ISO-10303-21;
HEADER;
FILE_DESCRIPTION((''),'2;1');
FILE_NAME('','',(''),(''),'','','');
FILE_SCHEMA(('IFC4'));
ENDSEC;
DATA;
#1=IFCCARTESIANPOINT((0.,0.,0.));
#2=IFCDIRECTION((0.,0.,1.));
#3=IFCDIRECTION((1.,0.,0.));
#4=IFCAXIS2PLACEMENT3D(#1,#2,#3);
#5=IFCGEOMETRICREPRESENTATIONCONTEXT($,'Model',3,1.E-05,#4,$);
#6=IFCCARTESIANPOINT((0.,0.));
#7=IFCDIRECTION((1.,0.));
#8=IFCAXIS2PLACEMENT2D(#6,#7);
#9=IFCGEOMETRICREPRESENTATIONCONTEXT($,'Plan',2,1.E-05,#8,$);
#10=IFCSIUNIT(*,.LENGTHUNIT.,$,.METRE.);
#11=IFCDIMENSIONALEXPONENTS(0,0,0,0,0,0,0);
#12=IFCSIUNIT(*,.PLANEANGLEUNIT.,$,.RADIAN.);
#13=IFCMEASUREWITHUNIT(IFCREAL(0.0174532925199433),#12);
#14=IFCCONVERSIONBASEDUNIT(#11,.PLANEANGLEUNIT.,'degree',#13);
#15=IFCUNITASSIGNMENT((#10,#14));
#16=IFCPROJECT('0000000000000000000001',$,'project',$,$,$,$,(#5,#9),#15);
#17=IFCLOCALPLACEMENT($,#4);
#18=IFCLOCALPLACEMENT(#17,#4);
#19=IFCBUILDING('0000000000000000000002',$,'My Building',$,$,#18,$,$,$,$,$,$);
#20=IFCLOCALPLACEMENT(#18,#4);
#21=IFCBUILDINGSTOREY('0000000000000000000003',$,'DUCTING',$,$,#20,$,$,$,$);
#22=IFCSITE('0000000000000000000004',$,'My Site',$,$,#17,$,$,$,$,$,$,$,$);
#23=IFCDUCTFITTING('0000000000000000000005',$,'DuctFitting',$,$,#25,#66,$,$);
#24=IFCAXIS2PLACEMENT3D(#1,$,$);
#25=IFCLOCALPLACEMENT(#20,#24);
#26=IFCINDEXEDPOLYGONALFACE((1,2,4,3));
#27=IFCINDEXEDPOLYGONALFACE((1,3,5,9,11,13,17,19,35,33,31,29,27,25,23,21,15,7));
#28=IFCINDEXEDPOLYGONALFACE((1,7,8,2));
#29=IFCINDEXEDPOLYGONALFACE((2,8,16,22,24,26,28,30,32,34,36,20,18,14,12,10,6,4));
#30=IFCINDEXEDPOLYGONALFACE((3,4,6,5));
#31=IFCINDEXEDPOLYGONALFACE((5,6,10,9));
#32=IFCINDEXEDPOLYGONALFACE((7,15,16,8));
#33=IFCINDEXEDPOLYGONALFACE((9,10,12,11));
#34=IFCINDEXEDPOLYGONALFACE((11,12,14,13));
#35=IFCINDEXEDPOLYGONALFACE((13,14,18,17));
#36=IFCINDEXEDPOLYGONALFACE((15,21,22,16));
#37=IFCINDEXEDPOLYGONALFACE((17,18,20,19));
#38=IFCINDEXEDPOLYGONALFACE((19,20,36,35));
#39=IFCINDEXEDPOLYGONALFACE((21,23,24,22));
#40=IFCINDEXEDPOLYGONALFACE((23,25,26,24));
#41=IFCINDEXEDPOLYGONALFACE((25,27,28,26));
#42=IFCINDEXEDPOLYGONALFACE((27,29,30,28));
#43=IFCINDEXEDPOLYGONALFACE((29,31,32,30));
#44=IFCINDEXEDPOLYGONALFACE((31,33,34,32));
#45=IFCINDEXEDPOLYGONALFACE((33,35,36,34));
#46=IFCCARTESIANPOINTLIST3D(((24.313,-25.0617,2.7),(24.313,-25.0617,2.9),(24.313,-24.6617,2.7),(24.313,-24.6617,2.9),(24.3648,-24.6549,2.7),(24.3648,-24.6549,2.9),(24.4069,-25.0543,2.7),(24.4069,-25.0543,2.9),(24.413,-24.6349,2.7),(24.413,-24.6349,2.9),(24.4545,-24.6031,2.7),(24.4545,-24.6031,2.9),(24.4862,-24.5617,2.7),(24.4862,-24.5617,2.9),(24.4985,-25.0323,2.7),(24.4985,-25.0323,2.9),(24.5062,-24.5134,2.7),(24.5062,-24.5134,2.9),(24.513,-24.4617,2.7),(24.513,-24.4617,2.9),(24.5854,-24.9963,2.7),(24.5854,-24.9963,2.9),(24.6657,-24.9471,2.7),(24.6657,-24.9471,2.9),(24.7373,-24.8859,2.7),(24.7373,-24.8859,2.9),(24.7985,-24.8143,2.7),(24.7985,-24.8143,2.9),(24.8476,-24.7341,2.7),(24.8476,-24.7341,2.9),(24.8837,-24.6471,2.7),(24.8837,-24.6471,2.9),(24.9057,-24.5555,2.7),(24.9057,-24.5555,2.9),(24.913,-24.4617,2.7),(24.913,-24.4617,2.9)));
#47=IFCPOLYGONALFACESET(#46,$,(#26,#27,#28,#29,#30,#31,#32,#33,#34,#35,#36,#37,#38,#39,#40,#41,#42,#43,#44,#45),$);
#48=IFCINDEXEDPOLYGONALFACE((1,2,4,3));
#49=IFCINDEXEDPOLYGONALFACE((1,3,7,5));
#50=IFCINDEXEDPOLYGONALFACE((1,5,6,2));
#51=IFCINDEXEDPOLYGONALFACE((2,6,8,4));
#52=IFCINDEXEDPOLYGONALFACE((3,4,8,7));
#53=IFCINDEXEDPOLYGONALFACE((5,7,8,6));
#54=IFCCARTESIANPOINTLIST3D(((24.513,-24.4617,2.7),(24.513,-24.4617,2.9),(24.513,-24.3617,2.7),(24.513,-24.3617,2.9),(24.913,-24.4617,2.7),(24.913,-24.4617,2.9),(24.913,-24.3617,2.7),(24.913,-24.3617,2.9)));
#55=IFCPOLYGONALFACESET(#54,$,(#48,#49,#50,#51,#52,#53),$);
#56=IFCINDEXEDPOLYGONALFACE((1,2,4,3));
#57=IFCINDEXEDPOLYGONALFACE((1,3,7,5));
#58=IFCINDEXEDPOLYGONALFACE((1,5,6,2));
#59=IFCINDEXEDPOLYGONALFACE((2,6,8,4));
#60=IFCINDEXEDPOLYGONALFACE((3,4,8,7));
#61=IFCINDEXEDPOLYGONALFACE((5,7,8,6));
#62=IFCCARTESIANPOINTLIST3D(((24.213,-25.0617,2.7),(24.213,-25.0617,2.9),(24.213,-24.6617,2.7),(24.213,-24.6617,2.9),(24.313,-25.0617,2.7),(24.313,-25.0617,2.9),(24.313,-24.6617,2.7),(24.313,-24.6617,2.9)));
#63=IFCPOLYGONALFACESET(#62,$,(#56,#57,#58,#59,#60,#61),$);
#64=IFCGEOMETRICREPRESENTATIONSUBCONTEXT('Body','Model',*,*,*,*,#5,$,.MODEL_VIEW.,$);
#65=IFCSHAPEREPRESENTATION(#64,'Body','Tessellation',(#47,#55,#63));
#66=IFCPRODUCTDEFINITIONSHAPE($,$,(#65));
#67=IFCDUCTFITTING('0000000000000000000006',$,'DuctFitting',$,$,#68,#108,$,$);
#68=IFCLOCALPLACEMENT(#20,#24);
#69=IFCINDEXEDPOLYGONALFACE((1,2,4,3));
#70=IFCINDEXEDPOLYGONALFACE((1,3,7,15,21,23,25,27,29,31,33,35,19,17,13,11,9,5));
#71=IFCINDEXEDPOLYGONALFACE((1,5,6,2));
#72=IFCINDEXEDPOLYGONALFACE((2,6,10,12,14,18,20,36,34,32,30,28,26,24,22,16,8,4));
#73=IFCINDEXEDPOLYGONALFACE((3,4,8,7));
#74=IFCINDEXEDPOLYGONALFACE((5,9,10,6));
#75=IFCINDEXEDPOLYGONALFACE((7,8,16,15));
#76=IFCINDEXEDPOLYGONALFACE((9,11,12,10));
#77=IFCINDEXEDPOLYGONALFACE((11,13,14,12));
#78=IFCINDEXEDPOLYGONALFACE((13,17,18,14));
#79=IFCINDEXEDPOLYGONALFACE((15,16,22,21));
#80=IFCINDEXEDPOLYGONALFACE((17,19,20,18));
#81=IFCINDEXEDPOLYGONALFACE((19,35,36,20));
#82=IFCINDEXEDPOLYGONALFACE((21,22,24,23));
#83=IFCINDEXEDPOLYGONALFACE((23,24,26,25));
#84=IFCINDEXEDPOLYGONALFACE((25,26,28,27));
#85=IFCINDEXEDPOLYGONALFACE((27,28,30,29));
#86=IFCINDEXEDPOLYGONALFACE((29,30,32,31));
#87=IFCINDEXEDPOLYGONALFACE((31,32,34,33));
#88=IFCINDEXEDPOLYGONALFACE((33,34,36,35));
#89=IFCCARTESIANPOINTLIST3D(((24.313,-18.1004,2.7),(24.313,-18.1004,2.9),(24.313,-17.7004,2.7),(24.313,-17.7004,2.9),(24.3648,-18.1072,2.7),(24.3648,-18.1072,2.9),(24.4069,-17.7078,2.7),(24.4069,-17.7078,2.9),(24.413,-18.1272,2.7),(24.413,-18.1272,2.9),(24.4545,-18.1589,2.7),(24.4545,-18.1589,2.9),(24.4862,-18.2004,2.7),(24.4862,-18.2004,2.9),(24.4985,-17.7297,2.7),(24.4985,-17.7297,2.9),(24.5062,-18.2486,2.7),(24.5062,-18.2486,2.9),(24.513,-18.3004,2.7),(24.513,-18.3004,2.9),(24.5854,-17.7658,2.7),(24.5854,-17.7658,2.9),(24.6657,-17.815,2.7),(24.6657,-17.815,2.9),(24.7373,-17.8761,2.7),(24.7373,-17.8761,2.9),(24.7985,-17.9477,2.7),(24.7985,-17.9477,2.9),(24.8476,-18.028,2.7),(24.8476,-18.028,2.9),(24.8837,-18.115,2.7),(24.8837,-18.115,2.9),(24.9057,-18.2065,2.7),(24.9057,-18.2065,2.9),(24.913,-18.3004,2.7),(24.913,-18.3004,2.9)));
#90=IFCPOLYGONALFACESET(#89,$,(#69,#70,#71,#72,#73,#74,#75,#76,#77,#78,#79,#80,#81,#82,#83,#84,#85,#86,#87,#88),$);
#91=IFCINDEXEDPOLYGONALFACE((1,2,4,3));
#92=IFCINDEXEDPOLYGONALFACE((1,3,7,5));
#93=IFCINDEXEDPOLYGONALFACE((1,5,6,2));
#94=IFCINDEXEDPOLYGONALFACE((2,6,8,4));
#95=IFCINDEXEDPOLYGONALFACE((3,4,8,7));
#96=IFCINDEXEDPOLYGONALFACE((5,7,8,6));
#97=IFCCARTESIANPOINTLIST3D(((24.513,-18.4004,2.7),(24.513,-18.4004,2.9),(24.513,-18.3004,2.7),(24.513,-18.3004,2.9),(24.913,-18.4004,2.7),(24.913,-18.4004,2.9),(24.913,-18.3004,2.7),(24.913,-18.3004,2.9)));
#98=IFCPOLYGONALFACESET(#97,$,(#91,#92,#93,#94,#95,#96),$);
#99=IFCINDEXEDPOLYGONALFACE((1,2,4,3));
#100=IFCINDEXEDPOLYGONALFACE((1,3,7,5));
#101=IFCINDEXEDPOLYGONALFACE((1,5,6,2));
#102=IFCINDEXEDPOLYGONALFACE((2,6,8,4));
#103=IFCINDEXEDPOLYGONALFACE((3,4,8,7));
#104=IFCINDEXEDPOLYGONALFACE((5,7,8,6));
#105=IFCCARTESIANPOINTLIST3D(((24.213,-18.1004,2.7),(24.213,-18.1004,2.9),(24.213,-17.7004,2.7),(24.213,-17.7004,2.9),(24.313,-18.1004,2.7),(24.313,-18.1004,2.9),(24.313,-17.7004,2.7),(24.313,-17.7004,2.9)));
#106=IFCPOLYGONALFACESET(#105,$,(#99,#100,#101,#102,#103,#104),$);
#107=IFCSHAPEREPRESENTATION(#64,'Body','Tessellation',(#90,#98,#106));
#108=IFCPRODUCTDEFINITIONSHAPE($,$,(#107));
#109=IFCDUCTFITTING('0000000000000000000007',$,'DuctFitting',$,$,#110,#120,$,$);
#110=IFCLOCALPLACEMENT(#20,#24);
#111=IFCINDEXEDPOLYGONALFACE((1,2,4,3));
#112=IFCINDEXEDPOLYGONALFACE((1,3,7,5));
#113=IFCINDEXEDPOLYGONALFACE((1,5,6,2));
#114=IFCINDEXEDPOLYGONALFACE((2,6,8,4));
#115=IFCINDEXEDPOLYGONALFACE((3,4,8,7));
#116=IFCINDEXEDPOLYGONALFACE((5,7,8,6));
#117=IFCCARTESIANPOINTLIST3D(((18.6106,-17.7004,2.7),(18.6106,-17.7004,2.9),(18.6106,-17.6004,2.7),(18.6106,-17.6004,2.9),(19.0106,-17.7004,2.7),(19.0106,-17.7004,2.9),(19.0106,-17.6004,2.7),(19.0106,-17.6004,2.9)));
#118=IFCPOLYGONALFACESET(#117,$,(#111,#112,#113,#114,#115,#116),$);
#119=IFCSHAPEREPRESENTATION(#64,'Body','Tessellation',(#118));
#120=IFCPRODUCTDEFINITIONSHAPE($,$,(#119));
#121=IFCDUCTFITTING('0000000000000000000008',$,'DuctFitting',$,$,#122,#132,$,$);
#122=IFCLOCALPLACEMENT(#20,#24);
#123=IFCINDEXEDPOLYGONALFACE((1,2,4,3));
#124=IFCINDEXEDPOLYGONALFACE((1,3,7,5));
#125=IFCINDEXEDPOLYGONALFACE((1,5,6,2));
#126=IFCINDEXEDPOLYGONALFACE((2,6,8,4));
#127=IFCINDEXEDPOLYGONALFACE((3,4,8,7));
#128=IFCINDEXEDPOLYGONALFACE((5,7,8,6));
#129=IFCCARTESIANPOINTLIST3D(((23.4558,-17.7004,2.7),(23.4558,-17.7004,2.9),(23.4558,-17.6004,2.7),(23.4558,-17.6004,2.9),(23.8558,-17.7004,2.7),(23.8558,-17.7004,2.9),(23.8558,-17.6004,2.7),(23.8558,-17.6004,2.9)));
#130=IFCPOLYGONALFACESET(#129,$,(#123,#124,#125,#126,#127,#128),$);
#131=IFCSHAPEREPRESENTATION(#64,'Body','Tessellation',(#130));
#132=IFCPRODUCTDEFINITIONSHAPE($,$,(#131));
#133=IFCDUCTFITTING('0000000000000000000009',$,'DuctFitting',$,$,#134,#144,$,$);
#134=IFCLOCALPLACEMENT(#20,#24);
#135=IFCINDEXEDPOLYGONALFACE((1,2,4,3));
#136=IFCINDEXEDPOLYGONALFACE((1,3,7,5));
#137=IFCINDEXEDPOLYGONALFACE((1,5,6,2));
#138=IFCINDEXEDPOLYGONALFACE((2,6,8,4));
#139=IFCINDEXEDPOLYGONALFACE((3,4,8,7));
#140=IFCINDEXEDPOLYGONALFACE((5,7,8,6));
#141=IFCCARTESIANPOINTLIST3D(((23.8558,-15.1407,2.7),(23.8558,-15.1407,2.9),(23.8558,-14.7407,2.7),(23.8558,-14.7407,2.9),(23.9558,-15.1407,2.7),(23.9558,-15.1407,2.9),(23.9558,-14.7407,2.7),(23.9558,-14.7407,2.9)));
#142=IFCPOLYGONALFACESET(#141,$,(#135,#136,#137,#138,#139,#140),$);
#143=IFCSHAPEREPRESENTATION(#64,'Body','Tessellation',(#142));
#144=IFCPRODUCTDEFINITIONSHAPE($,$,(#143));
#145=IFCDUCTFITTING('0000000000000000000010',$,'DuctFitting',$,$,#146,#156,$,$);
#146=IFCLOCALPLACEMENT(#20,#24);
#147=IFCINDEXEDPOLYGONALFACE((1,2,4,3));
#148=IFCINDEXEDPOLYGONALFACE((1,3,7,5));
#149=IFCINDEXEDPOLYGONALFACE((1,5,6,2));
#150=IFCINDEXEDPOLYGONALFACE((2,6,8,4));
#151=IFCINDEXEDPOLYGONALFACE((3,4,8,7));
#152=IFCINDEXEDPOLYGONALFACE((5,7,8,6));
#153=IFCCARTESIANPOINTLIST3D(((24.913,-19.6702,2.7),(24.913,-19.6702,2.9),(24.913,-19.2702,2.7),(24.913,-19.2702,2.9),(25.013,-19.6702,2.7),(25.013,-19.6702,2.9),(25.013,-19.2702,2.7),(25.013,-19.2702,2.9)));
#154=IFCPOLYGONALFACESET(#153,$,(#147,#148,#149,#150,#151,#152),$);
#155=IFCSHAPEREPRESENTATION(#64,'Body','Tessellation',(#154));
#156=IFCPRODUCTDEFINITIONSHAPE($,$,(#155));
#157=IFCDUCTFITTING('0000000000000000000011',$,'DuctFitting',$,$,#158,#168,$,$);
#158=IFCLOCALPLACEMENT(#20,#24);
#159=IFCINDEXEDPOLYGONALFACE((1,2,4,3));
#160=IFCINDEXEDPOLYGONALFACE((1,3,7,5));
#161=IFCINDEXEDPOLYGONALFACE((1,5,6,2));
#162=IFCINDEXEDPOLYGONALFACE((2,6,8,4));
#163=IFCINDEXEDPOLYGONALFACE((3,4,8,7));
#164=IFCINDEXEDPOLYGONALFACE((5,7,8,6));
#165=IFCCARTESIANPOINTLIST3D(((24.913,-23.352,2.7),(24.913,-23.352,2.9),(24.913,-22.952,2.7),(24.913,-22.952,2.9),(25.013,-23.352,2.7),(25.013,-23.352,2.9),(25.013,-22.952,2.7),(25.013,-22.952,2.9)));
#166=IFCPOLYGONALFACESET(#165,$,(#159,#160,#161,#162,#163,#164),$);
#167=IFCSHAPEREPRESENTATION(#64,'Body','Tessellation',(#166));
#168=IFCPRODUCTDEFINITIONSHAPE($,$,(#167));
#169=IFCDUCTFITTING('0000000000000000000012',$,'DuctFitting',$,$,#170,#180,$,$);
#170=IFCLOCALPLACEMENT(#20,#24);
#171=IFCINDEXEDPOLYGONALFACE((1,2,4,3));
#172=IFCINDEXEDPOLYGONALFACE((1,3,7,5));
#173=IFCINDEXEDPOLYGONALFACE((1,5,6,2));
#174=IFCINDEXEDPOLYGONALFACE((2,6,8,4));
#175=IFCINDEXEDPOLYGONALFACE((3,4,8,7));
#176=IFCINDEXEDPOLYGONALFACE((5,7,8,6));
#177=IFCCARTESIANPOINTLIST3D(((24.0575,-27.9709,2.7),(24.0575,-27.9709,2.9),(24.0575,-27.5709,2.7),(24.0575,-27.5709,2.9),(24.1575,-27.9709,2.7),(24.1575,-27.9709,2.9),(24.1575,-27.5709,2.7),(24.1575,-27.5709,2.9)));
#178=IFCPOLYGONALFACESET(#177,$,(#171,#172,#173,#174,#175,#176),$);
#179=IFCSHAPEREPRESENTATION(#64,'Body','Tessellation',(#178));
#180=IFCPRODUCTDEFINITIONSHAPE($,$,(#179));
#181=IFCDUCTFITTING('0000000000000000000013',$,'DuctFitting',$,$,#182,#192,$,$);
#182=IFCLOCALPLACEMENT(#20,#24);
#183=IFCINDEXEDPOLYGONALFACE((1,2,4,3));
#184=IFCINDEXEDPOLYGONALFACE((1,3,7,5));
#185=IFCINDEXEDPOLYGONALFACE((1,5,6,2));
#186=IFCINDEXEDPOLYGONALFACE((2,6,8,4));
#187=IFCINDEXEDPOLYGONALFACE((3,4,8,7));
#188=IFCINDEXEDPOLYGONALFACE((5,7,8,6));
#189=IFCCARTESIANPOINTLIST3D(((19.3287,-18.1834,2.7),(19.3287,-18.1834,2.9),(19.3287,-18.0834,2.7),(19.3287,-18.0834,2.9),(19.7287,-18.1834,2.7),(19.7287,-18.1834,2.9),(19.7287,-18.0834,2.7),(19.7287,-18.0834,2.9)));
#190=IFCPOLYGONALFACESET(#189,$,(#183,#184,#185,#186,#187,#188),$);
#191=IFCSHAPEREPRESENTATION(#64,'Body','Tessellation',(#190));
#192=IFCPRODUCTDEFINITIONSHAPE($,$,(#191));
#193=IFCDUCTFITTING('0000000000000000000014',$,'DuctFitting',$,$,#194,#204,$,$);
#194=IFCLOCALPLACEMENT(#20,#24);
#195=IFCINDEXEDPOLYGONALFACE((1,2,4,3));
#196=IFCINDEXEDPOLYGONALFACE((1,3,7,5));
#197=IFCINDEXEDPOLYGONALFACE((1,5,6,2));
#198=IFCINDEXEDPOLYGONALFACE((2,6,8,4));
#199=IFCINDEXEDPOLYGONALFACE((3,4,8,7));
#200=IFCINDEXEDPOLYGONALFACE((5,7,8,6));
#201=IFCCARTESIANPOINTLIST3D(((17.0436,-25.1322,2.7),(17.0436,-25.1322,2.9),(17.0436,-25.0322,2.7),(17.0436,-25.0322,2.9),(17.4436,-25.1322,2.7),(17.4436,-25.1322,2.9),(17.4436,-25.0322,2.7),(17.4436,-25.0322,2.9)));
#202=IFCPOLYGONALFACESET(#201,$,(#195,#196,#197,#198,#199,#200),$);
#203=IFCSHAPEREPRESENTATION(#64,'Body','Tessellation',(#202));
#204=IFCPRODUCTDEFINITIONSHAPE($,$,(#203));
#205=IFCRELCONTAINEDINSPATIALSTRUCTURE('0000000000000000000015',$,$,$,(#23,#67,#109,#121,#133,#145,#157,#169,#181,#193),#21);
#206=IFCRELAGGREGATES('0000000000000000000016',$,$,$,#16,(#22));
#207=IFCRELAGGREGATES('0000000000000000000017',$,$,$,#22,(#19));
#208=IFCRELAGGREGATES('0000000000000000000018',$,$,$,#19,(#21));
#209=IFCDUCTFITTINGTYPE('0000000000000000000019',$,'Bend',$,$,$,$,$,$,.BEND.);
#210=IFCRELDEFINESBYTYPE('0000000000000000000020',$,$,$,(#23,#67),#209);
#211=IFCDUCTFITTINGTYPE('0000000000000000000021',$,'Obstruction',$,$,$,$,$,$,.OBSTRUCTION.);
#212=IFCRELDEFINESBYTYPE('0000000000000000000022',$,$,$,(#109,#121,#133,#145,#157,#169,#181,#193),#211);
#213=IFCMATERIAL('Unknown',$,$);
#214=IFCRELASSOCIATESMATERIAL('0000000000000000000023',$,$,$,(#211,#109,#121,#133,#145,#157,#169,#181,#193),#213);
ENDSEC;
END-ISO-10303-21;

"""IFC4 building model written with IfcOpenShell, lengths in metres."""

from ifc_helpers import new_model, entity, si_unit, converted_unit, frame, origin_with_axes, origin_2d_with_axis, place, context, subcontext, project, spatial, line, arc, indexed_curve, rectangle, outline, extrude, source, transform, mapped, material, material_profile, profile_set, profile_usage, type_object, type_shapes, element, save


model = new_model("IFC4")

# Units and contexts
model_context = context("Model", 3, precision=1e-05, world=origin_with_axes())
plan_context = context("Plan", 2, precision=1e-05, world=origin_2d_with_axis())
body_context = subcontext(model_context, "Body", "Model", "MODEL_VIEW")
ifc_project = project(units=[si_unit("LENGTHUNIT", "METRE"), converted_unit("PLANEANGLEUNIT", "degree", entity("IfcReal", 0.0174532925199433), si_unit("PLANEANGLEUNIT", "RADIAN"), dimensions=[0, 0, 0, 0, 0, 0, 0])], contexts=[model_context, plan_context])

# Site, building, storey
site_placement = place(None, origin_with_axes())
site = spatial("IfcSite", under=ifc_project, at=site_placement, Name="My Site")
building_placement = place(site_placement, origin_with_axes())
building = spatial("IfcBuilding", under=site, at=building_placement, Name="My Building")
storey_placement = place(building_placement, origin_with_axes())
storey = spatial("IfcBuildingStorey", under=building, at=storey_placement, Name="DUCTING")

# Shared definitions
ifc_material = material(Name="Unknown")

# Duct fittings
duct_fitting_type_1 = type_object("IfcDuctFittingType", Name="Bend", PredefinedType="BEND")
shared_shape = source(origin_with_axes(), body_context, "Body", "SweptSolid", [
    extrude(outline(indexed_curve([(-0.2, 0.0), (-0.2586, 0.1414), (-0.4, 0.2), (-0.4, 0.6), (0.0243, 0.4243), (0.2, 0.0)], segments=[arc(1, 2, 3), line(3, 4), arc(4, 5, 6), line(6, 1)])), frame((0.0, -0.1, 0.1), z_axis=(0.0, -1.0, 0.0), x_axis=(1.0, 0.0, 0.0)), (0.0, 0.0, -1.0), 0.2),
    extrude(rectangle(XDim=0.4, YDim=0.2), origin_with_axes(), (0.0, 0.0, 1.0), 0.1),
    extrude(rectangle(XDim=0.4, YDim=0.2), frame((-0.4, 0.0, 0.5), z_axis=(-1.0, 0.0, 0.0), x_axis=(0.0, 0.0, -1.0)), (0.0, 0.0, 1.0), 0.1),
])
type_shapes(duct_fitting_type_1, [shared_shape])
for number, where, z_axis, x_axis, name in (
    (1, (24.713, -24.3617, 2.8), (0.0, -1.0, 0.0), (1.0, 0.0, 0.0), "DuctFitting"),
    (2, (24.713, -18.4004, 2.8), (0.0, 1.0, 0.0), (1.0, 0.0, 0.0), "DuctFitting"),
):
    element("IfcDuctFitting", number, at=place(storey_placement, frame(where, z_axis=z_axis, x_axis=x_axis)), inside=storey, type_object=duct_fitting_type_1, Name=name, context=body_context, shape_type="MappedRepresentation", body=[
        mapped(shared_shape, transform((0.0, 0.0, 0.0), x_axis=(1.0, 0.0, 0.0), y_axis=(0.0, 1.0, 0.0), z_axis=(0.0, 0.0, 1.0), scale=1.0)),
    ])
ifc_material_profile_1 = material_profile(ifc_material, rectangle(XDim=0.4, YDim=0.2))
ifc_profile_set_1 = profile_set([ifc_material_profile_1])
ifc_profile_usage_1 = profile_usage(ifc_profile_set_1, cardinal=5)
duct_fitting_type_2 = type_object("IfcDuctFittingType", Name="Obstruction", PredefinedType="OBSTRUCTION", material=ifc_profile_set_1)
duct_fitting_1_placement = place(storey_placement, frame((18.8106, -17.7004, 2.8), z_axis=(0.0, 1.0, 0.0), x_axis=(-1.0, 0.0, 0.0)))
element("IfcDuctFitting", 3, at=duct_fitting_1_placement, inside=storey, type_object=duct_fitting_type_2, material=ifc_profile_usage_1, Name="DuctFitting", context=body_context, shape_type="SweptSolid", body=[
    extrude(rectangle(XDim=0.4, YDim=0.2), origin_with_axes(), (0.0, 0.0, 1.0), 0.1),
])
ifc_profile_usage_2 = profile_usage(ifc_profile_set_1, cardinal=5)
duct_fitting_2_placement = place(storey_placement, frame((23.6558, -17.7004, 2.8), z_axis=(0.0, 1.0, 0.0), x_axis=(-1.0, 0.0, 0.0)))
element("IfcDuctFitting", 4, at=duct_fitting_2_placement, inside=storey, type_object=duct_fitting_type_2, material=ifc_profile_usage_2, Name="DuctFitting", context=body_context, shape_type="SweptSolid", body=[
    extrude(rectangle(XDim=0.4, YDim=0.2), origin_with_axes(), (0.0, 0.0, 1.0), 0.1),
])
ifc_profile_usage_3 = profile_usage(ifc_profile_set_1, cardinal=5)
duct_fitting_3_placement = place(storey_placement, frame((23.8558, -14.9407, 2.8), z_axis=(1.0, 0.0, 0.0), x_axis=(0.0, 1.0, 0.0)))
element("IfcDuctFitting", 5, at=duct_fitting_3_placement, inside=storey, type_object=duct_fitting_type_2, material=ifc_profile_usage_3, Name="DuctFitting", context=body_context, shape_type="SweptSolid", body=[
    extrude(rectangle(XDim=0.4, YDim=0.2), origin_with_axes(), (0.0, 0.0, 1.0), 0.1),
])
ifc_profile_usage_4 = profile_usage(ifc_profile_set_1, cardinal=5)
duct_fitting_4_placement = place(storey_placement, frame((24.913, -19.4702, 2.8), z_axis=(1.0, 0.000001, -0.000001), x_axis=(-0.000001, 1.0, 0.0)))
element("IfcDuctFitting", 6, at=duct_fitting_4_placement, inside=storey, type_object=duct_fitting_type_2, material=ifc_profile_usage_4, Name="DuctFitting", context=body_context, shape_type="SweptSolid", body=[
    extrude(rectangle(XDim=0.4, YDim=0.2), origin_with_axes(), (0.0, 0.0, 1.0), 0.1),
])
ifc_profile_usage_5 = profile_usage(ifc_profile_set_1, cardinal=5)
duct_fitting_5_placement = place(storey_placement, frame((24.913, -23.152, 2.8), z_axis=(1.0, 0.000001, -0.000001), x_axis=(-0.000001, 1.0, 0.0)))
element("IfcDuctFitting", 7, at=duct_fitting_5_placement, inside=storey, type_object=duct_fitting_type_2, material=ifc_profile_usage_5, Name="DuctFitting", context=body_context, shape_type="SweptSolid", body=[
    extrude(rectangle(XDim=0.4, YDim=0.2), origin_with_axes(), (0.0, 0.0, 1.0), 0.1),
])
ifc_profile_usage_6 = profile_usage(ifc_profile_set_1, cardinal=5)
duct_fitting_6_placement = place(storey_placement, frame((24.0575, -27.7709, 2.8), z_axis=(1.0, 0.0, 0.0), x_axis=(0.0, 1.0, 0.0)))
element("IfcDuctFitting", 8, at=duct_fitting_6_placement, inside=storey, type_object=duct_fitting_type_2, material=ifc_profile_usage_6, Name="DuctFitting", context=body_context, shape_type="SweptSolid", body=[
    extrude(rectangle(XDim=0.4, YDim=0.2), origin_with_axes(), (0.0, 0.0, 1.0), 0.1),
])
ifc_profile_usage_7 = profile_usage(ifc_profile_set_1, cardinal=5)
duct_fitting_7_placement = place(storey_placement, frame((19.5287, -18.1834, 2.8), z_axis=(-0.000001, 1.0, 0.0), x_axis=(-1.0, -0.000001, 0.0)))
element("IfcDuctFitting", 9, at=duct_fitting_7_placement, inside=storey, type_object=duct_fitting_type_2, material=ifc_profile_usage_7, Name="DuctFitting", context=body_context, shape_type="SweptSolid", body=[
    extrude(rectangle(XDim=0.4, YDim=0.2), origin_with_axes(), (0.0, 0.0, 1.0), 0.1),
])
ifc_profile_usage_8 = profile_usage(ifc_profile_set_1, cardinal=5)
duct_fitting_8_placement = place(storey_placement, frame((17.2436, -25.1322, 2.8), z_axis=(0.0, 1.0, 0.0), x_axis=(-1.0, 0.0, 0.0)))
element("IfcDuctFitting", 10, at=duct_fitting_8_placement, inside=storey, type_object=duct_fitting_type_2, material=ifc_profile_usage_8, Name="DuctFitting", context=body_context, shape_type="SweptSolid", body=[
    extrude(rectangle(XDim=0.4, YDim=0.2), origin_with_axes(), (0.0, 0.0, 1.0), 0.1),
])

save(model, "model.ifc")
